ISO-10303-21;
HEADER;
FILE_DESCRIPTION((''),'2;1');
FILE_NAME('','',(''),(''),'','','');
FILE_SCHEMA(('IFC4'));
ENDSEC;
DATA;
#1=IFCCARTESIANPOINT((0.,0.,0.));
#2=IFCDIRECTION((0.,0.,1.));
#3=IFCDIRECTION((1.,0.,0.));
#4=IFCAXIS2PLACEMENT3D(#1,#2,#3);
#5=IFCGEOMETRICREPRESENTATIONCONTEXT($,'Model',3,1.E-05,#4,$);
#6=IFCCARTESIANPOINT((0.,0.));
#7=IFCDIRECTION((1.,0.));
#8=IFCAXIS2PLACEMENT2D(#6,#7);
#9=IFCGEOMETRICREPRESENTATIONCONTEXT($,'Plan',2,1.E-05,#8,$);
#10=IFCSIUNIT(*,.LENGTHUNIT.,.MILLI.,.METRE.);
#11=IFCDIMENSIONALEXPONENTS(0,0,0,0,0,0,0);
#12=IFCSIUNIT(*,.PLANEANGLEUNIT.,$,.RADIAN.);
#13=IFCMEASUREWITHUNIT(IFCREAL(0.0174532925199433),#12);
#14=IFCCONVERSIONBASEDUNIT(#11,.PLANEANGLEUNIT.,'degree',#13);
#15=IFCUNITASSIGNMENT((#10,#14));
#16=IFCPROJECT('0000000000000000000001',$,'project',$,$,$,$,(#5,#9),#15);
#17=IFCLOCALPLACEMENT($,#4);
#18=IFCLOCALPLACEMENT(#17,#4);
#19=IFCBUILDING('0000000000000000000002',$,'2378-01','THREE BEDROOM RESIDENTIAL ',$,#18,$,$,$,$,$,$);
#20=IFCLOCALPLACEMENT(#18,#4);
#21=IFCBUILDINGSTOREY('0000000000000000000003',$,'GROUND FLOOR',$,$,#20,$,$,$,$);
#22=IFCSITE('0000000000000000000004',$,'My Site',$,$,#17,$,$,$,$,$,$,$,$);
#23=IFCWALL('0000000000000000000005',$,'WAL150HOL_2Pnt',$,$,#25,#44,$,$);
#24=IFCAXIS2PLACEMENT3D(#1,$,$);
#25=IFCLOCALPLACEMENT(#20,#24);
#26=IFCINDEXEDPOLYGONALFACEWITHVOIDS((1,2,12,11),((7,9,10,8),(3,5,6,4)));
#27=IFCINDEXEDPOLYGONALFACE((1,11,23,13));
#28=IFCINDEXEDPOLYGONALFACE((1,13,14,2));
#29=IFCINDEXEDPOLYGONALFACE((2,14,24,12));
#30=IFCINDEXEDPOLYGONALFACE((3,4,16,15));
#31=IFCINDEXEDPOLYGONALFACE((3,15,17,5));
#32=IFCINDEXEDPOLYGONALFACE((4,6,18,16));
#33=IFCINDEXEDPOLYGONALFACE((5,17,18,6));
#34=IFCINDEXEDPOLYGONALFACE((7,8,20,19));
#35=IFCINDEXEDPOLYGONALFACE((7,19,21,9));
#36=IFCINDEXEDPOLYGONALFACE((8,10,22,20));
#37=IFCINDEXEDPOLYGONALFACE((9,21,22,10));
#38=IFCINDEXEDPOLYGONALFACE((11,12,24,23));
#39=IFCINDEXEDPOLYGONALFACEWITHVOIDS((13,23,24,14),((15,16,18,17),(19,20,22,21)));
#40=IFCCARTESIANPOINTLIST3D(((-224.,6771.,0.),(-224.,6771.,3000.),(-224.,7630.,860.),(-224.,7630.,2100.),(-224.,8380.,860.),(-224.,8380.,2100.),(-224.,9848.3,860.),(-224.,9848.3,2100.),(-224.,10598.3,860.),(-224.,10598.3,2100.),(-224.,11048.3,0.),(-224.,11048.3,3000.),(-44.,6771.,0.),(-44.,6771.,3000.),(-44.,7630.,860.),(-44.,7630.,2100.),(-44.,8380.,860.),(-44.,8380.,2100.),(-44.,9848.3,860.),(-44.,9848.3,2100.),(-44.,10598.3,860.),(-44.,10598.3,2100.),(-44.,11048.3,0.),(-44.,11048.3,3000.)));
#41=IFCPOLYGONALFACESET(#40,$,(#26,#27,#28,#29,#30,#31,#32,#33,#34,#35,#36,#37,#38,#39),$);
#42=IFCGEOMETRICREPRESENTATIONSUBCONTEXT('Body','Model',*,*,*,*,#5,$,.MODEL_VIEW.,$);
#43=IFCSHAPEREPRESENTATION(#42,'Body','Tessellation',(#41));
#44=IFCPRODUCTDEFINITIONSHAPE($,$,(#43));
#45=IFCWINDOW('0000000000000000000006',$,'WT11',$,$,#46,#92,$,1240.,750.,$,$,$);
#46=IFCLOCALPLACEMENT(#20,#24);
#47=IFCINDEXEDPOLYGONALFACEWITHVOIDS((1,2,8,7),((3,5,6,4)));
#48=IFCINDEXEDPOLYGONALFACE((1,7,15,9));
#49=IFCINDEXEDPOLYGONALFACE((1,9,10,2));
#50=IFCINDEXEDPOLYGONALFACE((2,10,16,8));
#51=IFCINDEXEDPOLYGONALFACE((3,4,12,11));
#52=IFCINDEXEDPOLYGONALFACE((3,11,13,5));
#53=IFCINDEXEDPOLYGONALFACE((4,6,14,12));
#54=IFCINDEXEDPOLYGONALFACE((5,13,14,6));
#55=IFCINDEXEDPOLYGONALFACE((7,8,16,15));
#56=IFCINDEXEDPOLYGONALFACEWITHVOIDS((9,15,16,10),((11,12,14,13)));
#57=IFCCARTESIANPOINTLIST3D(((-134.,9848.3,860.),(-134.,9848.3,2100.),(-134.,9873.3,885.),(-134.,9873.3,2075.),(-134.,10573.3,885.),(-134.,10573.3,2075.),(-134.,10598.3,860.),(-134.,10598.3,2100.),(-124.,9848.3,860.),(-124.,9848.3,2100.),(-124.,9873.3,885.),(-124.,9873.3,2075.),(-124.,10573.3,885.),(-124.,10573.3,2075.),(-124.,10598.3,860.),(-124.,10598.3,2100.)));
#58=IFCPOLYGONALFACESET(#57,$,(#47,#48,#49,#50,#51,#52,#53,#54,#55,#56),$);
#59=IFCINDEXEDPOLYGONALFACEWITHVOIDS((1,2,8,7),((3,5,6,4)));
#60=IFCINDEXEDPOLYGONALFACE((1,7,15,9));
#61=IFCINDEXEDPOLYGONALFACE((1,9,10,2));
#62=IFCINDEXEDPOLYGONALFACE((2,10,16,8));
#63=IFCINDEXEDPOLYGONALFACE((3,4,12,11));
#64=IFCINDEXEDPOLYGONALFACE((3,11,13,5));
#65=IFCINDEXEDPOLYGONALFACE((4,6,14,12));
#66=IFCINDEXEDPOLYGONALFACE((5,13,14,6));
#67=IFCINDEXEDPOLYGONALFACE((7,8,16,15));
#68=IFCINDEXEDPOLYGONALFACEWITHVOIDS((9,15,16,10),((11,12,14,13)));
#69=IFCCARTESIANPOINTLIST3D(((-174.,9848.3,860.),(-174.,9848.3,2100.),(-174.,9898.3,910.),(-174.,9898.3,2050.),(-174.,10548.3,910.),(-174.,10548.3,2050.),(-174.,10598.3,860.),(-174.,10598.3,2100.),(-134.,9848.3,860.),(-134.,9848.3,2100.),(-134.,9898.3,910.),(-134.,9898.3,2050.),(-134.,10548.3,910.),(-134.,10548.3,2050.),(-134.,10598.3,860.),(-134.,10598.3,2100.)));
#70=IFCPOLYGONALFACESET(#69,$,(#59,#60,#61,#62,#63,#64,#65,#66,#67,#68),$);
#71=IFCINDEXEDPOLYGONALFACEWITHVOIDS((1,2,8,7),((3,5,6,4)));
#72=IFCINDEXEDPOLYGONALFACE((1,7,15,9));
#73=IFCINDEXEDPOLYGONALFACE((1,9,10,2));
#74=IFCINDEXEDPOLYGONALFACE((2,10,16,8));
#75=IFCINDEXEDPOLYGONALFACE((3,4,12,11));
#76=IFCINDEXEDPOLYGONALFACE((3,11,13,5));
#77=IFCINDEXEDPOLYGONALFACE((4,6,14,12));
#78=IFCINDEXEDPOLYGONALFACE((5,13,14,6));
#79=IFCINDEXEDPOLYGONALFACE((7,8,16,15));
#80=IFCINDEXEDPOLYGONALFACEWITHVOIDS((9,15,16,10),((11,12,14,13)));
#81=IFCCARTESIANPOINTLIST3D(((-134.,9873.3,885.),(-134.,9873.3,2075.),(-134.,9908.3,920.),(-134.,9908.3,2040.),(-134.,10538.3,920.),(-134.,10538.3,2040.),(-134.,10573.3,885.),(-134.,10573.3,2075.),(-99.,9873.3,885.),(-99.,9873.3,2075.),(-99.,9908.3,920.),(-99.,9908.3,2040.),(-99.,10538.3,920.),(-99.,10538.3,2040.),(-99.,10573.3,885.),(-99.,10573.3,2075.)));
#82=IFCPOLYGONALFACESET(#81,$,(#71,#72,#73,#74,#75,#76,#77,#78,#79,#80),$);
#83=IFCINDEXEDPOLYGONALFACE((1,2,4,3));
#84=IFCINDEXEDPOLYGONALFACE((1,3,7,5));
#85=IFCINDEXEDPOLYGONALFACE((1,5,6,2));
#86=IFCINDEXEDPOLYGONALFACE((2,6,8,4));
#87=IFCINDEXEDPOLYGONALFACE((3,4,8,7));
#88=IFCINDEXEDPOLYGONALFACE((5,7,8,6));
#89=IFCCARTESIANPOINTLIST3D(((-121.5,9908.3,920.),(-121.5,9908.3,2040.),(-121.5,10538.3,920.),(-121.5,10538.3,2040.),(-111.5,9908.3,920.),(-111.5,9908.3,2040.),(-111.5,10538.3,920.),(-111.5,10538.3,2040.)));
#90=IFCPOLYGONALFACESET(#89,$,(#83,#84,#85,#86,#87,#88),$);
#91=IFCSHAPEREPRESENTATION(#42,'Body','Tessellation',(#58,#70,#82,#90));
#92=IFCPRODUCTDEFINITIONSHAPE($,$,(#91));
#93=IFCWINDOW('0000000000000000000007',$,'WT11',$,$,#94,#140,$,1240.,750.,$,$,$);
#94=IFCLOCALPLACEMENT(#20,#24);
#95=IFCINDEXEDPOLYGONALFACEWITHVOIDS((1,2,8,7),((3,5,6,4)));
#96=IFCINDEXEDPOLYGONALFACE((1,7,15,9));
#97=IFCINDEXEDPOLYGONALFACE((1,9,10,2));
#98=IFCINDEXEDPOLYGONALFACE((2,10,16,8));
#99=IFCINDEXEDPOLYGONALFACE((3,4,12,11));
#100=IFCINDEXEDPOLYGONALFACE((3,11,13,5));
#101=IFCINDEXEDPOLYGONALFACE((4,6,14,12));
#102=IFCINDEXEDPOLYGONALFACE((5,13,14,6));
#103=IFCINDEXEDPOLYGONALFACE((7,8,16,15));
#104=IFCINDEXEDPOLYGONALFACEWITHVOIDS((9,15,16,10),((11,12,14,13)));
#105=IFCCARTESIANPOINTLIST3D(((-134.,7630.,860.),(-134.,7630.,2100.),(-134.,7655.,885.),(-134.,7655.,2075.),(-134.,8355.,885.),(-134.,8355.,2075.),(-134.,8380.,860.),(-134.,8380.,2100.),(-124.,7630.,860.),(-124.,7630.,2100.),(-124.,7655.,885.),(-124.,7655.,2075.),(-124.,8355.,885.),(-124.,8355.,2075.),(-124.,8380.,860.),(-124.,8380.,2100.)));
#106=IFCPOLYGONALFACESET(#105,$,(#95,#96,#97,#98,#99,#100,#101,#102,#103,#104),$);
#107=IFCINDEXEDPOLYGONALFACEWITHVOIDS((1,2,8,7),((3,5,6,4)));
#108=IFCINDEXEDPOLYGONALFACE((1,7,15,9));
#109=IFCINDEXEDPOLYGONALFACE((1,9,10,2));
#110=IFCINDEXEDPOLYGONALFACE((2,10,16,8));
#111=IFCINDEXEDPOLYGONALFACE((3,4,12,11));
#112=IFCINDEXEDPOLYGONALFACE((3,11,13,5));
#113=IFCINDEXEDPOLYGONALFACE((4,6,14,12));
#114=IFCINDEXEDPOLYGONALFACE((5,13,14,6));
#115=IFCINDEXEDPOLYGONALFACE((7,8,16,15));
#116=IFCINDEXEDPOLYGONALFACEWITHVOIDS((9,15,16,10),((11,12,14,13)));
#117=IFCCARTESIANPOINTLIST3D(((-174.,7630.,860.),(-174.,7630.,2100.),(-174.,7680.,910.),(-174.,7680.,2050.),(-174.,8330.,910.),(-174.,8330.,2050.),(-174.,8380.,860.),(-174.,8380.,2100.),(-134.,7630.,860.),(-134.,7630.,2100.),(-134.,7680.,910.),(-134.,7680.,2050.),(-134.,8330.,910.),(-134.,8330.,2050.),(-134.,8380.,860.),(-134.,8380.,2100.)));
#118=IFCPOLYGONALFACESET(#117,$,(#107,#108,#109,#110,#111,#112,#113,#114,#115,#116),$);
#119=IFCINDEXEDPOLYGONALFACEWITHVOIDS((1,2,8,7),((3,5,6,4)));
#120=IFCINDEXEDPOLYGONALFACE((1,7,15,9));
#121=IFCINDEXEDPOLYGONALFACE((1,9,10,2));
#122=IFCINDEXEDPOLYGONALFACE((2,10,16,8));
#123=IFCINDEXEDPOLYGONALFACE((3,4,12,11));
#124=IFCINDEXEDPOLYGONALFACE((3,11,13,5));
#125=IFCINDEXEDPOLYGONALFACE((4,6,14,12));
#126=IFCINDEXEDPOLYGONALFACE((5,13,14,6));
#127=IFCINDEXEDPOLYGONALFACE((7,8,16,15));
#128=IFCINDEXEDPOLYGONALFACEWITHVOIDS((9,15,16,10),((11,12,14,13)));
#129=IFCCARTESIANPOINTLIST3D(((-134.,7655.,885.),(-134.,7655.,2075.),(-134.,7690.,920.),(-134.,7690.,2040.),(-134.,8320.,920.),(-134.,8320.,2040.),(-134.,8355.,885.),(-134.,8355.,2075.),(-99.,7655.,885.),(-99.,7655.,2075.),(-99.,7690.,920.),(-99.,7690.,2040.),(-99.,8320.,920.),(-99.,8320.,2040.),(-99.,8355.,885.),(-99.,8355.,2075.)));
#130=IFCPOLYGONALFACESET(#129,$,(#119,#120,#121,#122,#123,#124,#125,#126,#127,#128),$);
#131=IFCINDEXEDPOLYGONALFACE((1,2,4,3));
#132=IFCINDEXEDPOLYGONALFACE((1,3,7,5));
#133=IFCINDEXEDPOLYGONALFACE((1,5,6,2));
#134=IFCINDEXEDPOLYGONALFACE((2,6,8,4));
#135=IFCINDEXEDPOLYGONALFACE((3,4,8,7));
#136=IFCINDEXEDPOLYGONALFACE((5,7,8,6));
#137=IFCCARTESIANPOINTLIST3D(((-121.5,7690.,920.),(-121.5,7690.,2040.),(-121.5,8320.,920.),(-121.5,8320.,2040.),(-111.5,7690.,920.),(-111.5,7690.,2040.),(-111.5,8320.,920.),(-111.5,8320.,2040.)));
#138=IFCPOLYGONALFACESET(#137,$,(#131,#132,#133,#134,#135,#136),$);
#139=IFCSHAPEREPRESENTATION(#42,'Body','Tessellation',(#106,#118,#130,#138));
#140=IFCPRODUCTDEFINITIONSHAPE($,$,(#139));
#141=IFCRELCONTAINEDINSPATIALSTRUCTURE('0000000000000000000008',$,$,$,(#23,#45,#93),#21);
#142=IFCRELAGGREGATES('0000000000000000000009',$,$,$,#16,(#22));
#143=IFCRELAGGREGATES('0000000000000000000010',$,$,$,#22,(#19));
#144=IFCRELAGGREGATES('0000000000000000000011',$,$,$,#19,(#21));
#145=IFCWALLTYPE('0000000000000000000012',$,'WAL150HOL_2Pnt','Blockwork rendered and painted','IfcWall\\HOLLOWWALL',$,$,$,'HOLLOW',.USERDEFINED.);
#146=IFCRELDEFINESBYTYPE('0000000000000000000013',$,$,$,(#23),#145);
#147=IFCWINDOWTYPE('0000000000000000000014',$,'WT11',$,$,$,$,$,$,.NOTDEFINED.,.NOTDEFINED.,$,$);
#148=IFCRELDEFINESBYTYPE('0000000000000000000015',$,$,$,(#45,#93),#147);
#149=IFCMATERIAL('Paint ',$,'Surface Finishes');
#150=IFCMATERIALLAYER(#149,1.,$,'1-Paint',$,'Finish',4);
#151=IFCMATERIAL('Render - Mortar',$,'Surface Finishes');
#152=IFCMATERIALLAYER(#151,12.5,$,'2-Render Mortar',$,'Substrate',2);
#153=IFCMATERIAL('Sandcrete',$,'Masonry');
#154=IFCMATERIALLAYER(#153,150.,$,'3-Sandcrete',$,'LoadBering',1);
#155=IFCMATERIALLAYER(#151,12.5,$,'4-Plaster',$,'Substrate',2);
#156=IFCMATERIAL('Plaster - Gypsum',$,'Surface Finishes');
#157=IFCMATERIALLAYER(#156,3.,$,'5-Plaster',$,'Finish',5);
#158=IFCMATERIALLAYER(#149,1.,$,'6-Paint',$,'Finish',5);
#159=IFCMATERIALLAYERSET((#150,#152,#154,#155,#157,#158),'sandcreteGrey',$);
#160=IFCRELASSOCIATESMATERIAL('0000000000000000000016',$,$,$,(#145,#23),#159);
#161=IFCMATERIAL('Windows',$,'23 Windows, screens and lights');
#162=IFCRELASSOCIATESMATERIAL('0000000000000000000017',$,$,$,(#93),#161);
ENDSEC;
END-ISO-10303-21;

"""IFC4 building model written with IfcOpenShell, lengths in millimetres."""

from ifc_helpers import new_model, entity, si_unit, converted_unit, frame, origin_with_axes, origin_2d_with_axis, place, context, subcontext, project, spatial, line, indexed_curve, outline, extrude, shape, source, transform, mapped, material, layer, layer_set, layer_usage, type_object, type_shapes, element, fill, save


model = new_model("IFC4")

# Units and contexts
model_context = context("Model", 3, precision=1e-05, world=origin_with_axes())
plan_context = context("Plan", 2, precision=1e-05, world=origin_2d_with_axis())
body_context_1 = subcontext(model_context, "Body", "Model", "MODEL_VIEW")
body_context_2 = subcontext(plan_context, "Body", "Plan", "PLAN_VIEW")
ifc_project = project(units=[si_unit("LENGTHUNIT", "METRE", prefix="MILLI"), converted_unit("PLANEANGLEUNIT", "degree", entity("IfcReal", 0.0174532925199433), si_unit("PLANEANGLEUNIT", "RADIAN"), dimensions=[0, 0, 0, 0, 0, 0, 0])], contexts=[model_context, plan_context])

# Site, building, storey
site_placement = place(None, origin_with_axes())
site = spatial("IfcSite", under=ifc_project, at=site_placement, Name="My Site")
building_placement = place(site_placement, origin_with_axes())
building = spatial("IfcBuilding", under=site, at=building_placement, Name="2378-01", Description="THREE BEDROOM RESIDENTIAL ")
storey_placement = place(building_placement, origin_with_axes())
storey = spatial("IfcBuildingStorey", under=building, at=storey_placement, Name="GROUND FLOOR")

# Shared definitions
ifc_material_1 = material(Name="Paint ", Category="Surface Finishes")
ifc_layer_1 = layer(ifc_material_1, 1.0, Name="1-Paint", Category="Finish", Priority=4)
ifc_material_2 = material(Name="Render - Mortar", Category="Surface Finishes")
ifc_layer_2 = layer(ifc_material_2, 12.5, Name="2-Render Mortar", Category="Substrate", Priority=2)
ifc_material_3 = material(Name="Sandcrete", Category="Masonry")
ifc_layer_3 = layer(ifc_material_3, 150.0, Name="3-Sandcrete", Category="LoadBering", Priority=1)
ifc_layer_4 = layer(ifc_material_2, 12.5, Name="4-Plaster", Category="Substrate", Priority=2)
ifc_material_4 = material(Name="Plaster - Gypsum", Category="Surface Finishes")
ifc_layer_5 = layer(ifc_material_4, 3.0, Name="5-Plaster", Category="Finish", Priority=5)
ifc_layer_6 = layer(ifc_material_1, 1.0, Name="6-Paint", Category="Finish", Priority=5)
ifc_layer_set_1 = layer_set([ifc_layer_1, ifc_layer_2, ifc_layer_3, ifc_layer_4, ifc_layer_5, ifc_layer_6], Name="sandcreteGrey")
wall_type_1 = type_object("IfcWallType", Name="WAL150HOL_2Pnt", Description="Blockwork rendered and painted", ApplicableOccurrence="IfcWall\\HOLLOWWALL", ElementType="HOLLOW", PredefinedType="USERDEFINED", material=ifc_layer_set_1)

# Shared definitions
shared_shape_1 = source(origin_with_axes(), body_context_1, "Body", "SweptSolid", [
    extrude(outline(indexed_curve([(0.0, 0.0), (750.0, 0.0), (750.0, 1240.0), (0.0, 1240.0)], segments=[line(1, 2, 3, 4, 1)])), frame((0.0, -100.0, 0.0), z_axis=(0.0, -1.0, 0.0), x_axis=(1.0, 0.0, 0.0)), (0.0, 0.0, -1.0), 380.0),
])
window_type_1 = type_object("IfcWindowType", Name="WT11", PartitioningType="NOTDEFINED", PredefinedType="NOTDEFINED")
shared_shape_2 = source(origin_with_axes(), body_context_1, "Body", "SweptSolid", [
    extrude(outline(indexed_curve([(0.0, 0.0), (750.0, 0.0), (750.0, 1240.0), (0.0, 1240.0)], segments=[line(1, 2, 3, 4, 1)]), holes=[indexed_curve([(25.0, 25.0), (725.0, 25.0), (725.0, 1215.0), (25.0, 1215.0)], segments=[line(1, 2, 3, 4, 1)])]), frame((0.0, 90.0, 0.0), z_axis=(0.0, -1.0, 0.0), x_axis=(1.0, 0.0, 0.0)), (0.0, 0.0, -1.0), 10.0),
    extrude(outline(indexed_curve([(0.0, 0.0), (750.0, 0.0), (750.0, 1240.0), (0.0, 1240.0)], segments=[line(1, 2, 3, 4, 1)]), holes=[indexed_curve([(50.0, 50.0), (700.0, 50.0), (700.0, 1190.0), (50.0, 1190.0)], segments=[line(1, 2, 3, 4, 1)])]), frame((0.0, 50.0, 0.0), z_axis=(0.0, -1.0, 0.0), x_axis=(1.0, 0.0, 0.0)), (0.0, 0.0, -1.0), 40.0),
    extrude(outline(indexed_curve([(0.0, 0.0), (700.0, 0.0), (700.0, 1190.0), (0.0, 1190.0)], segments=[line(1, 2, 3, 4, 1)]), holes=[indexed_curve([(35.0, 35.0), (665.0, 35.0), (665.0, 1155.0), (35.0, 1155.0)], segments=[line(1, 2, 3, 4, 1)])]), frame((25.0, 90.0, 25.0), z_axis=(0.0, -1.0, 0.0), x_axis=(1.0, 0.0, 0.0)), (0.0, 0.0, -1.0), 35.0),
    extrude(outline(indexed_curve([(35.0, 35.0), (665.0, 35.0), (665.0, 1155.0), (35.0, 1155.0)], segments=[line(1, 2, 3, 4, 1)])), frame((25.0, 102.5, 25.0), z_axis=(0.0, -1.0, 0.0), x_axis=(1.0, 0.0, 0.0)), (0.0, 0.0, -1.0), 10.0),
])
shared_shape_3 = source(origin_with_axes(), body_context_2, "Body", "Curve2D", [
    entity("IfcIndexedPolyCurve", entity("IfcCartesianPointList2D", [[50.0, 50.0], [700.0, 50.0]])),
    entity("IfcIndexedPolyCurve", entity("IfcCartesianPointList2D", [[0.0, 100.0], [25.0, 100.0], [25.0, 90.0], [50.0, 90.0], [50.0, 50.0], [0.0, 50.0]]), [entity("IfcLineIndex", [1, 2, 3, 4, 5, 6, 1])]),
    entity("IfcIndexedPolyCurve", entity("IfcCartesianPointList2D", [[750.0, 100.0], [725.0, 100.0], [725.0, 90.0], [700.0, 90.0], [700.0, 50.0], [750.0, 50.0]]), [entity("IfcLineIndex", [1, 2, 3, 4, 5, 6, 1])]),
    entity("IfcIndexedPolyCurve", entity("IfcCartesianPointList2D", [[25.0, 90.0], [60.0, 90.0], [60.0, 125.0], [25.0, 125.0]]), [entity("IfcLineIndex", [1, 2, 3, 4, 1])]),
    entity("IfcIndexedPolyCurve", entity("IfcCartesianPointList2D", [[725.0, 90.0], [690.0, 90.0], [690.0, 125.0], [725.0, 125.0]]), [entity("IfcLineIndex", [1, 2, 3, 4, 1])]),
    entity("IfcIndexedPolyCurve", entity("IfcCartesianPointList2D", [[60.0, 90.0], [690.0, 90.0]])),
    entity("IfcIndexedPolyCurve", entity("IfcCartesianPointList2D", [[60.0, 125.0], [690.0, 125.0]])),
    entity("IfcIndexedPolyCurve", entity("IfcCartesianPointList2D", [[60.0, 107.5], [690.0, 107.5]])),
])
type_shapes(window_type_1, [shared_shape_2, shared_shape_3])

# Wall, openings, windows
ifc_layer_usage_1 = layer_usage(ifc_layer_set_1, "AXIS2", "POSITIVE", 0.0)
wall_1_placement = place(storey_placement, frame((-224.0, 11048.3, 0.0), z_axis=(0.0, 0.0, 1.0), x_axis=(0.0, -1.0, 0.0)))
wall_1 = element("IfcWall", 1, at=wall_1_placement, inside=storey, type_object=wall_type_1, material=ifc_layer_usage_1, Name="WAL150HOL_2Pnt", context=body_context_1, shape_type="SweptSolid", body=[
    extrude(outline(indexed_curve([(0.0, 0.0), (0.0, 180.0), (4277.3, 180.0), (4277.3, 0.0), (0.0, 0.0)], self_intersect=False)), origin_with_axes(), (0.0, 0.0, 1.0), 3000.0),
])
opening_1_placement = place(wall_1_placement, frame((450.0, 0.0, 860.0), z_axis=(0.0, 0.0, 1.0), x_axis=(1.0, 0.0, 0.0)))
opening_1 = element("IfcOpeningElement", 2, at=opening_1_placement, cuts=wall_1, PredefinedType="OPENING", context=body_context_1, shape_type="MappedRepresentation", body=[
    mapped(shared_shape_1, transform((0.0, 0.0, 0.0), x_axis=(1.0, 0.0, 0.0), y_axis=(0.0, 1.0, 0.0), z_axis=(0.0, 0.0, 1.0), scale=1.0)),
])
opening_2_placement = place(wall_1_placement, frame((2668.3, 0.0, 860.0), z_axis=(0.0, 0.0, 1.0), x_axis=(1.0, 0.0, 0.0)))
opening_2 = element("IfcOpeningElement", 3, at=opening_2_placement, cuts=wall_1, PredefinedType="OPENING", context=body_context_1, shape_type="MappedRepresentation", body=[
    mapped(shared_shape_1, transform((0.0, 0.0, 0.0), x_axis=(1.0, 0.0, 0.0), y_axis=(0.0, 1.0, 0.0), z_axis=(0.0, 0.0, 1.0), scale=1.0)),
])
window_1_placement = place(opening_1_placement, frame((0.0, 0.0, 0.0), z_axis=(0.0, 0.0, 1.0), x_axis=(1.0, 0.0, 0.0)))
window_1 = element("IfcWindow", 4, at=window_1_placement, inside=storey, type_object=window_type_1, Name="WT11", OverallHeight=1240.0, OverallWidth=750.0, shapes=[
    shape(body_context_1, "Body", "MappedRepresentation", [mapped(shared_shape_2, transform((0.0, 0.0, 0.0), x_axis=(1.0, 0.0, 0.0), y_axis=(0.0, 1.0, 0.0), z_axis=(0.0, 0.0, 1.0), scale=1.0))]),
    shape(body_context_2, "Body", "MappedRepresentation", [mapped(shared_shape_3, transform((0.0, 0.0, 0.0), x_axis=(1.0, 0.0, 0.0), y_axis=(0.0, 1.0, 0.0), z_axis=(0.0, 0.0, 1.0), scale=1.0))]),
])
fill(opening_1, window_1)
ifc_material_5 = material(Name="Windows", Category="23 Windows, screens and lights")
window_2_placement = place(opening_2_placement, frame((0.0, 0.0, 0.0), z_axis=(0.0, 0.0, 1.0), x_axis=(1.0, 0.0, 0.0)))
window_2 = element("IfcWindow", 5, at=window_2_placement, inside=storey, type_object=window_type_1, material=ifc_material_5, Name="WT11", OverallHeight=1240.0, OverallWidth=750.0, shapes=[
    shape(body_context_1, "Body", "MappedRepresentation", [mapped(shared_shape_2, transform((0.0, 0.0, 0.0), x_axis=(1.0, 0.0, 0.0), y_axis=(0.0, 1.0, 0.0), z_axis=(0.0, 0.0, 1.0), scale=1.0))]),
    shape(body_context_2, "Body", "MappedRepresentation", [mapped(shared_shape_3, transform((0.0, 0.0, 0.0), x_axis=(1.0, 0.0, 0.0), y_axis=(0.0, 1.0, 0.0), z_axis=(0.0, 0.0, 1.0), scale=1.0))]),
])
fill(opening_2, window_2)

save(model, "model.ifc")
